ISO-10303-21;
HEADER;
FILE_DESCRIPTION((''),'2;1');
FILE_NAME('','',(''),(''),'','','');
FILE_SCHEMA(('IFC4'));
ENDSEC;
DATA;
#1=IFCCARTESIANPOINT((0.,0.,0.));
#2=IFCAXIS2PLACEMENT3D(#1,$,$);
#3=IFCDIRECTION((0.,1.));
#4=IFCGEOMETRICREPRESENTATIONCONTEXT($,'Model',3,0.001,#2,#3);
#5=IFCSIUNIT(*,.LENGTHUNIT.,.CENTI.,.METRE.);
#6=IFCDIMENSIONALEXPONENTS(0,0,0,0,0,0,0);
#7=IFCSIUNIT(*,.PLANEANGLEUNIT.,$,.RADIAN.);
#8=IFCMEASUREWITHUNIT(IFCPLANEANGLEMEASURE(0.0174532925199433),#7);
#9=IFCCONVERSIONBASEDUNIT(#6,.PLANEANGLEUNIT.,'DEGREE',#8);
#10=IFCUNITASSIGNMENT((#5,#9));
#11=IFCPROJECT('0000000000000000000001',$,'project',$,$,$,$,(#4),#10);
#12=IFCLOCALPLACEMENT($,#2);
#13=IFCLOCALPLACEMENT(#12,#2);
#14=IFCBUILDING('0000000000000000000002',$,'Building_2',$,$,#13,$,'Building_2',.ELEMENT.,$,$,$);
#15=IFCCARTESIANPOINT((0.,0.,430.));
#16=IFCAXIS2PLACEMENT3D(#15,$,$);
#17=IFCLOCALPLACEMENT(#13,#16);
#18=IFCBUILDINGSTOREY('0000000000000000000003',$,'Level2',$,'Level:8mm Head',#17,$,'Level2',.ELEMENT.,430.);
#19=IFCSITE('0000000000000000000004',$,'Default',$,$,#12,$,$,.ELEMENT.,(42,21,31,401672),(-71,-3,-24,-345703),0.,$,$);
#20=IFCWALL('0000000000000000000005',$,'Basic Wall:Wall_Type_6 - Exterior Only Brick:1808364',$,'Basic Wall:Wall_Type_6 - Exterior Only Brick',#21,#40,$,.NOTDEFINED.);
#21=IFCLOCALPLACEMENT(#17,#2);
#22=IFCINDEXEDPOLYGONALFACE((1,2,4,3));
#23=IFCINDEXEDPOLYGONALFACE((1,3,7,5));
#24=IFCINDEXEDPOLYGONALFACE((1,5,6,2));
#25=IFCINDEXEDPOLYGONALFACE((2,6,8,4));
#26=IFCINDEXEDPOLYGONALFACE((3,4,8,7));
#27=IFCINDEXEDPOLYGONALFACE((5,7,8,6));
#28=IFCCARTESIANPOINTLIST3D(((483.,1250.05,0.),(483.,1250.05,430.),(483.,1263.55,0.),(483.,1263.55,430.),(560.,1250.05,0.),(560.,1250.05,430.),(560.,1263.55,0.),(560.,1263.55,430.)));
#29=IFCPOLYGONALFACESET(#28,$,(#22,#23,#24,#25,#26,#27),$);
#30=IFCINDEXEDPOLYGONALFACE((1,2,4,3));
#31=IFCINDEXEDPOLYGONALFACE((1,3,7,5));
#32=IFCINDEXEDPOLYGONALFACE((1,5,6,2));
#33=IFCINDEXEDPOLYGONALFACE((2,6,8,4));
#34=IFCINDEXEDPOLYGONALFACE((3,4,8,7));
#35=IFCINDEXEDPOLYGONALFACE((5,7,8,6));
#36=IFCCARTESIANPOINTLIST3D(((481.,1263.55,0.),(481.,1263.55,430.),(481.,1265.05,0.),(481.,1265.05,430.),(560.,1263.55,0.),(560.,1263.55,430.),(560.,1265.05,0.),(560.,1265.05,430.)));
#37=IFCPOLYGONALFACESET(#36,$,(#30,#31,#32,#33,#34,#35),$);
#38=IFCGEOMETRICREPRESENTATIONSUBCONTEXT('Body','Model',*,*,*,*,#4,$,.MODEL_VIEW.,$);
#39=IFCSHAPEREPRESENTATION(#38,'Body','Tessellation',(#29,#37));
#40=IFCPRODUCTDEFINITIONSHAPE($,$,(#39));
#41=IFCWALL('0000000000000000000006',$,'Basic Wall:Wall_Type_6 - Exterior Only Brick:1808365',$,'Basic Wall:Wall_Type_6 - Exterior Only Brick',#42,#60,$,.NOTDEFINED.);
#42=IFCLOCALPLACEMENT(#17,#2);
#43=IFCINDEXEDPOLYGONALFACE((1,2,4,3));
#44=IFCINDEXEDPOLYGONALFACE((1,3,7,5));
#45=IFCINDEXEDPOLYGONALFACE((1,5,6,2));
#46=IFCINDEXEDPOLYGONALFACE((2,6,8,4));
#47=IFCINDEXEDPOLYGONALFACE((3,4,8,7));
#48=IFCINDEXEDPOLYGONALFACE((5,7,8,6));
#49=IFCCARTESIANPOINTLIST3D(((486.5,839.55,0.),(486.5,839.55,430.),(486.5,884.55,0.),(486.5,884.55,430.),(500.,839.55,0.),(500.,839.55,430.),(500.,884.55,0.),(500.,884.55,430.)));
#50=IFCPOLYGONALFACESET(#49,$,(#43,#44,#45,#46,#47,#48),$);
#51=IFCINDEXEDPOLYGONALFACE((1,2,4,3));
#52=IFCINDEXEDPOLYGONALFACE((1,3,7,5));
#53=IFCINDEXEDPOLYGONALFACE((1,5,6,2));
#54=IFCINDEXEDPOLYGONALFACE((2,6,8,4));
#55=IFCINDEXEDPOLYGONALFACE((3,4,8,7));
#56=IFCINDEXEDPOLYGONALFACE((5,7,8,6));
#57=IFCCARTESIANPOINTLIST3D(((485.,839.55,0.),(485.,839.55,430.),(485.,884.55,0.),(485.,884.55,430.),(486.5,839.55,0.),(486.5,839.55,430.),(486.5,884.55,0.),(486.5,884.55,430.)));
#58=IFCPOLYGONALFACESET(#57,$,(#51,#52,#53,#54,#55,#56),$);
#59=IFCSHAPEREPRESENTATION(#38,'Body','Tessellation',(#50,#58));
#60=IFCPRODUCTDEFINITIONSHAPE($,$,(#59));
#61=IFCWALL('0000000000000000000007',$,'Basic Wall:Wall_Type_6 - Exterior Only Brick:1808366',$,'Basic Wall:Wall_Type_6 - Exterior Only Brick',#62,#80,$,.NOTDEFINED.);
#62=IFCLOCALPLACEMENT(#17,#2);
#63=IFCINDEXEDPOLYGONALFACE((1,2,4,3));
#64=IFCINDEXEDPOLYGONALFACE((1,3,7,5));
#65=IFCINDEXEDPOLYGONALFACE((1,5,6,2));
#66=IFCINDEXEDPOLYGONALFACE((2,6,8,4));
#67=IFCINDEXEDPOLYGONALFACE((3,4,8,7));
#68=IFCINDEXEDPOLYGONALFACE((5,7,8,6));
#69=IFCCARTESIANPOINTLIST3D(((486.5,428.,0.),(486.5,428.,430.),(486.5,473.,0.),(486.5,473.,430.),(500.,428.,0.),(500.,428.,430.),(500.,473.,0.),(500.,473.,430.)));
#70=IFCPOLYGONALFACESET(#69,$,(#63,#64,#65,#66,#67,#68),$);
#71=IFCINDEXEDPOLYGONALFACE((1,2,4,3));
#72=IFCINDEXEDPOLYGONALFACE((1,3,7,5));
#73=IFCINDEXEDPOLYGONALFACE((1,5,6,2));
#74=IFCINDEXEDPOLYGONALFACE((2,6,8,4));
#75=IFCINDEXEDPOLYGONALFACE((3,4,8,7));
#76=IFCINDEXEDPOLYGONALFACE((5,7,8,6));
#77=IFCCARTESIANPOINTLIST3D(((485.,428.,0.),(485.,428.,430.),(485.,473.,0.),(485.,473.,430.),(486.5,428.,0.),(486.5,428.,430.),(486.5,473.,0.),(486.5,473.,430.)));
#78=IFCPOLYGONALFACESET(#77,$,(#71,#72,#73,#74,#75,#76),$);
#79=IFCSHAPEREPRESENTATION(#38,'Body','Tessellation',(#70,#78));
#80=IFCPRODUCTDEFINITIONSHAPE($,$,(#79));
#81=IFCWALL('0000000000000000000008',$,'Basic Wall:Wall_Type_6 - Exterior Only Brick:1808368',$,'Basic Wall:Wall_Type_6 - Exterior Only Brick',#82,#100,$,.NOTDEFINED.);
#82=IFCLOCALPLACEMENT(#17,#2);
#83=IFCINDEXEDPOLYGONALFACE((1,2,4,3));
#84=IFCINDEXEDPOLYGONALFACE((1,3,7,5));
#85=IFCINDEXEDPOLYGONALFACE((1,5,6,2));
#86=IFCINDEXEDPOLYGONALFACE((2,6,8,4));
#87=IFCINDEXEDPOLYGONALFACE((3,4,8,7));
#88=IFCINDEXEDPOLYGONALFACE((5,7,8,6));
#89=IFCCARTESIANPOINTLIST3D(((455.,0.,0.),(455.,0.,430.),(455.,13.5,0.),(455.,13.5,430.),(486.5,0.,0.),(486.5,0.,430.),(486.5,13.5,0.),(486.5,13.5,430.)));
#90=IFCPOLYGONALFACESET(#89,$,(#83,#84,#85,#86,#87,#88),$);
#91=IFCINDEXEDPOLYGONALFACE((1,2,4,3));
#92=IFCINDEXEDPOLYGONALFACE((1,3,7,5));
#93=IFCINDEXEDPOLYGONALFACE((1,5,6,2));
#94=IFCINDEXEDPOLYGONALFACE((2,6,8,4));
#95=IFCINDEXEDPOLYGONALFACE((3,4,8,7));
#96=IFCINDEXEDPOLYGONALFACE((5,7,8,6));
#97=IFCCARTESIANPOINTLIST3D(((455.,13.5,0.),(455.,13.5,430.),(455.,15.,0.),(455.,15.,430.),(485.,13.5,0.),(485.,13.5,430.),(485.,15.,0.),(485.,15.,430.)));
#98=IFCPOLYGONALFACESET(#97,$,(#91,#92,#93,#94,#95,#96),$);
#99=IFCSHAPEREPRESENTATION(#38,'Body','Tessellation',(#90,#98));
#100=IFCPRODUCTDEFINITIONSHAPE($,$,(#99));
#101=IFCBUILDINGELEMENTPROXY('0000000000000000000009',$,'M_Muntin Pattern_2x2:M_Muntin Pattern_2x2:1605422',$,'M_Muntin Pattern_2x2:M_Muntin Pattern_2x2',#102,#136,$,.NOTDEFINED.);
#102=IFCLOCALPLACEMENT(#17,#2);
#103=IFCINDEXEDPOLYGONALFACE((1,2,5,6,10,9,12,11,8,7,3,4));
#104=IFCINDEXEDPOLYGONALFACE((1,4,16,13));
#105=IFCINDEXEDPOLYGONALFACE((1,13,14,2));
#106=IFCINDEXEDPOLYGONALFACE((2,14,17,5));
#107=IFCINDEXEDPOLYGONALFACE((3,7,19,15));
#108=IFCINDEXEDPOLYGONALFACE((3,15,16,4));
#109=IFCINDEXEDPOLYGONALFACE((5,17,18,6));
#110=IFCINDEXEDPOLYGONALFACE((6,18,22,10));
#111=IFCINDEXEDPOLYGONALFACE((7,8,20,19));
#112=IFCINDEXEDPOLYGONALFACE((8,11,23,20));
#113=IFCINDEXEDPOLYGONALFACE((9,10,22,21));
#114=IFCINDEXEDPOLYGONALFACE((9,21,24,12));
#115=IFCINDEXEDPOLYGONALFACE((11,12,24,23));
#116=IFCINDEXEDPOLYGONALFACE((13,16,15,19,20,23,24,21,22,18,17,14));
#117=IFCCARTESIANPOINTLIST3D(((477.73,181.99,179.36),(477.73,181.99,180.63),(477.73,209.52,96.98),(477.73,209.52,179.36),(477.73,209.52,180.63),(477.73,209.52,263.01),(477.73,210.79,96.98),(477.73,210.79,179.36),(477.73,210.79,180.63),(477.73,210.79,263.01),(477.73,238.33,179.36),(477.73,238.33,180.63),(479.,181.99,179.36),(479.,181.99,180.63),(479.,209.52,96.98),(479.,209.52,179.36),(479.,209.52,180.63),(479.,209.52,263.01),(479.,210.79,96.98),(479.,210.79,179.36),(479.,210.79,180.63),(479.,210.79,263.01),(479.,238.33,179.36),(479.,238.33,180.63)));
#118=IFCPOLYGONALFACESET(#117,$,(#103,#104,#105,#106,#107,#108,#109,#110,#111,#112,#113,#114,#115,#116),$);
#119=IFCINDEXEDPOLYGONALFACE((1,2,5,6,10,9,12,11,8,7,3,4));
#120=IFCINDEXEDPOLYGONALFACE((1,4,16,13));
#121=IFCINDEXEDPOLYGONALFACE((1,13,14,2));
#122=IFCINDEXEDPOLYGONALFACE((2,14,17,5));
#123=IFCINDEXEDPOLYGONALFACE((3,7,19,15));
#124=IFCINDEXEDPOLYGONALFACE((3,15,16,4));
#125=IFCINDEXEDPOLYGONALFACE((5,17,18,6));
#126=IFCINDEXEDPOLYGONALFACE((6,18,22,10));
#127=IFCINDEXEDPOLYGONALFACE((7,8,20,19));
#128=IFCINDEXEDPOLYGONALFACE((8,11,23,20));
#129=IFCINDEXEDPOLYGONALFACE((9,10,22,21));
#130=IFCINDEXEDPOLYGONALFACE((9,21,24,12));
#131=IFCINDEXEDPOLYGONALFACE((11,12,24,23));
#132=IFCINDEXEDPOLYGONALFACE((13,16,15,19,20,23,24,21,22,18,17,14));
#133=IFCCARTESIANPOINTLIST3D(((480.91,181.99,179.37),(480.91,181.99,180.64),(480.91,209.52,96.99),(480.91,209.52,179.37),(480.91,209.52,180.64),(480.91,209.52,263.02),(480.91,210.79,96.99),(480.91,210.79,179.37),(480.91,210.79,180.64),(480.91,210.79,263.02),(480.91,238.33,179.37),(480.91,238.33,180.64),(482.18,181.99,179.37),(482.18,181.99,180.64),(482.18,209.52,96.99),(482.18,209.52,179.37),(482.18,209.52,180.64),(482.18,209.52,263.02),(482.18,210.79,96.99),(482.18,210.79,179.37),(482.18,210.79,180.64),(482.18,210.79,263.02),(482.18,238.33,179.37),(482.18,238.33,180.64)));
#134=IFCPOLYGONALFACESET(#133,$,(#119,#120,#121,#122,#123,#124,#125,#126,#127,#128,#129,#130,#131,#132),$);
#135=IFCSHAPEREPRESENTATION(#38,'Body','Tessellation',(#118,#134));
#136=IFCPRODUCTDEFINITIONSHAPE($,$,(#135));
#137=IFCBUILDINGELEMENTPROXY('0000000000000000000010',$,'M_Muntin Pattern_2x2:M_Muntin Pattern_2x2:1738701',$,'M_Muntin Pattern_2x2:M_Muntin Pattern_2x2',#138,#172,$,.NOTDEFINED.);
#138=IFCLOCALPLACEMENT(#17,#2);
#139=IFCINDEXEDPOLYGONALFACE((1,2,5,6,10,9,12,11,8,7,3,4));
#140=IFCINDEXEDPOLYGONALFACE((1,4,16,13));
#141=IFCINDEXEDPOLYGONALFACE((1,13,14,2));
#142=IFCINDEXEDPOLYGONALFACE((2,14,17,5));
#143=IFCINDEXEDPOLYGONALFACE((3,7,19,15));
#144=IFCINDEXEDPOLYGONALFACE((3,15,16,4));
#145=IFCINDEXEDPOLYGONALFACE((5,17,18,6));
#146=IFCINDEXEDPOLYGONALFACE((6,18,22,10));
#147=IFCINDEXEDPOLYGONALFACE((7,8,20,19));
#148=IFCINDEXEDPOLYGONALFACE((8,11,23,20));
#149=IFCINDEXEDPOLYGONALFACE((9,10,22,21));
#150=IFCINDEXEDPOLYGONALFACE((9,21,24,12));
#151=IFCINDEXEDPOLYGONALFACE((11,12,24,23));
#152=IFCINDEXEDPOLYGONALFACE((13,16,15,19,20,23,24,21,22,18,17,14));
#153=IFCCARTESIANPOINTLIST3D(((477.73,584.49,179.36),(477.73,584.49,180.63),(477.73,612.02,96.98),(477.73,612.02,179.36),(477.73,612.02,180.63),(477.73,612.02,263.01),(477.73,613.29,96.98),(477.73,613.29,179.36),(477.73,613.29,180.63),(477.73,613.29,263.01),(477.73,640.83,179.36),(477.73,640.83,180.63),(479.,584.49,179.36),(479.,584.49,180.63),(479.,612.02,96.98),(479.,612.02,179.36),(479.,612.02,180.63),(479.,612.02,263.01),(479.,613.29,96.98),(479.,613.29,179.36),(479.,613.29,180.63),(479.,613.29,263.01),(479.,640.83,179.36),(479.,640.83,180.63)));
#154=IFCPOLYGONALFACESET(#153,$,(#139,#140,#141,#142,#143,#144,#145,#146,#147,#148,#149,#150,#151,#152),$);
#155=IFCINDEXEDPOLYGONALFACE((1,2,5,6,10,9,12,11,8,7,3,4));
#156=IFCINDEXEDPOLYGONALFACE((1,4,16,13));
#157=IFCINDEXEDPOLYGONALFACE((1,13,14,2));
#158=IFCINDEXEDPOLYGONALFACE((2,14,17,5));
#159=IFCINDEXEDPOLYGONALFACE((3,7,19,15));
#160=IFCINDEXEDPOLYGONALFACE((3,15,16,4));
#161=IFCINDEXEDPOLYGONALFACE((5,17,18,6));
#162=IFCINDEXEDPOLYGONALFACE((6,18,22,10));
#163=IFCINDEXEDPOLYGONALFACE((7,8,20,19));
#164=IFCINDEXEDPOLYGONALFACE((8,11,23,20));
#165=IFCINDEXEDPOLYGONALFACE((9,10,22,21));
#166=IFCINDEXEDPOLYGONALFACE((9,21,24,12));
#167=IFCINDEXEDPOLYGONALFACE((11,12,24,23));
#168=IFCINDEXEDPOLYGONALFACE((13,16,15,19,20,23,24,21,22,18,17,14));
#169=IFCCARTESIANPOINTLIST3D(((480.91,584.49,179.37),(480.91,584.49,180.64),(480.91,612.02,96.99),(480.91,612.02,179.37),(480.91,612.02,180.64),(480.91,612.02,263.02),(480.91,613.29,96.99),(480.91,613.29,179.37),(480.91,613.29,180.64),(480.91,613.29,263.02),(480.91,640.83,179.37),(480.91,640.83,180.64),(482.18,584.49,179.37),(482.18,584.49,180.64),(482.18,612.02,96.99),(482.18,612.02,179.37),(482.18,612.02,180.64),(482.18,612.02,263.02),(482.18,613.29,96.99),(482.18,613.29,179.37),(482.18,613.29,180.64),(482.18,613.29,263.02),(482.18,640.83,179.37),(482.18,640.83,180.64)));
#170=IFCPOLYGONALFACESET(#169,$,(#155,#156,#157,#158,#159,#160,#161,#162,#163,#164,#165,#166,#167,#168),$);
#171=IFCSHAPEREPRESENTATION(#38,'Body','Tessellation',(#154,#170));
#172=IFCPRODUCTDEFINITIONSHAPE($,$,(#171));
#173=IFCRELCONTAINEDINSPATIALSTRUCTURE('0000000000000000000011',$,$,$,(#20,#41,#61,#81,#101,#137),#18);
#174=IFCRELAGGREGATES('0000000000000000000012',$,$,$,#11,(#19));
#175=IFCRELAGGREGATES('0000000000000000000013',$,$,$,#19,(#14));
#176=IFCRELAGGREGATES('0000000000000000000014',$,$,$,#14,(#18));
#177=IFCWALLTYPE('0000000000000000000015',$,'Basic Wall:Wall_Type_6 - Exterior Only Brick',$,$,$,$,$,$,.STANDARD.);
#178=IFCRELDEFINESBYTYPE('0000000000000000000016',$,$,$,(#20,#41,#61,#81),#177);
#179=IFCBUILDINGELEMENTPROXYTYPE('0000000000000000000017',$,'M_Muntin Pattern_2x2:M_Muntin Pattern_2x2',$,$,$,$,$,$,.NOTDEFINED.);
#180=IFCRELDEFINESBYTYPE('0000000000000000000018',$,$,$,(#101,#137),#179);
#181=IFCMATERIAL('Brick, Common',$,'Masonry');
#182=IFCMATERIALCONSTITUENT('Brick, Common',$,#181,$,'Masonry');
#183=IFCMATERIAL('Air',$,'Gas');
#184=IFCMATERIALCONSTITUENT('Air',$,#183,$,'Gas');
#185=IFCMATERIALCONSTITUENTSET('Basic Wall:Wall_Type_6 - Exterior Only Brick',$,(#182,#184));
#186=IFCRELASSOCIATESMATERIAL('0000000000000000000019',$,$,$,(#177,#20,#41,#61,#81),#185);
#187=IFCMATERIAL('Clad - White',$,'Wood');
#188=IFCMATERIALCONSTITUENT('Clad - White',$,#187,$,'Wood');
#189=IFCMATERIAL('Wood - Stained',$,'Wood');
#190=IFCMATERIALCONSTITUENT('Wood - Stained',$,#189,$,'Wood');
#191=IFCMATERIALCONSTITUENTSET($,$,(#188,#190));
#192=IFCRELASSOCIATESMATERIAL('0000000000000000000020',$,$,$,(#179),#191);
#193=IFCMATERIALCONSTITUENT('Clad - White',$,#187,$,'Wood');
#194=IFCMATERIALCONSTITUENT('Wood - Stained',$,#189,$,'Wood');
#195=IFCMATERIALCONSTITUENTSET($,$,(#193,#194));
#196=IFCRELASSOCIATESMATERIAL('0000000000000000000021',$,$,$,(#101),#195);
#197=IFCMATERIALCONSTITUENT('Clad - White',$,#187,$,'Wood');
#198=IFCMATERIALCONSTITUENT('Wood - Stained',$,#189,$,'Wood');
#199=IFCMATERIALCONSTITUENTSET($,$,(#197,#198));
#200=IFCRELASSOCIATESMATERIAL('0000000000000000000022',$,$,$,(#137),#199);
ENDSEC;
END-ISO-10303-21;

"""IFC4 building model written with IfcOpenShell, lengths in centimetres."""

from ifc_helpers import new_model, entity, si_unit, converted_unit, direction, frame, origin, place, context, subcontext, project, spatial, indexed_curve, outline, extrude, source, transform, mapped, material, constituent, constituent_set, type_object, type_shapes, element, save


model = new_model("IFC4")

# Units and contexts
model_context = context("Model", 3, precision=0.001, world=origin(), true_north=direction((0.0, 1.0)))
body_context = subcontext(model_context, "Body", "Model", "MODEL_VIEW")
ifc_project = project(units=[si_unit("LENGTHUNIT", "METRE", prefix="CENTI"), converted_unit("PLANEANGLEUNIT", "DEGREE", entity("IfcPlaneAngleMeasure", 0.0174532925199433), si_unit("PLANEANGLEUNIT", "RADIAN"), dimensions=[0, 0, 0, 0, 0, 0, 0])], contexts=[model_context])

# Site, building, storey
site_placement = place(None, origin())
site = spatial("IfcSite", under=ifc_project, at=site_placement, Name="Default", CompositionType="ELEMENT", RefLatitude=(42, 21, 31, 401672), RefLongitude=(-71, -3, -24, -345703), RefElevation=0.0)
building_placement = place(site_placement, origin())
building = spatial("IfcBuilding", under=site, at=building_placement, Name="Building_2", LongName="Building_2", CompositionType="ELEMENT")
storey_placement = place(building_placement, frame((0.0, 0.0, 430.0)))
storey = spatial("IfcBuildingStorey", under=building, at=storey_placement, Name="Level2", ObjectType="Level:8mm Head", LongName="Level2", CompositionType="ELEMENT", Elevation=430.0)

# Shared definitions
ifc_material_1 = material(Name="Brick, Common", Category="Masonry")
ifc_material_2 = material(Name="Air", Category="Gas")

# Walls
ifc_constituent_1 = constituent(ifc_material_1, Name="Brick, Common", Category="Masonry")
ifc_constituent_2 = constituent(ifc_material_2, Name="Air", Category="Gas")
ifc_constituent_set_1 = constituent_set(constituents=[ifc_constituent_1, ifc_constituent_2], Name="Basic Wall:Wall_Type_6 - Exterior Only Brick")
wall_type_1 = type_object("IfcWallType", Name="Basic Wall:Wall_Type_6 - Exterior Only Brick", PredefinedType="STANDARD", material=ifc_constituent_set_1)
wall_1_placement = place(storey_placement, frame((560.0, 1257.55, 0.0), z_axis=(0.0, 0.0, 1.0), x_axis=(-1.0, 0.0, 0.0)))
element("IfcWall", 1, at=wall_1_placement, inside=storey, type_object=wall_type_1, material=ifc_constituent_set_1, Name="Basic Wall:Wall_Type_6 - Exterior Only Brick:1808364", ObjectType="Basic Wall:Wall_Type_6 - Exterior Only Brick", PredefinedType="NOTDEFINED", context=body_context, shape_type="SweptSolid", body=[
    extrude(outline(indexed_curve([(-6.75, -38.5), (6.75, -38.5), (6.75, 38.5), (-6.75, 38.5), (-6.75, -38.5)], self_intersect=False)), frame((38.5, 0.75, 0.0), z_axis=(0.0, 0.0, 1.0), x_axis=(0.0, -1.0, 0.0)), (0.0, 0.0, 1.0), 430.0),
    extrude(outline(indexed_curve([(-0.75, -39.5), (0.75, -39.5), (0.75, 39.5), (-0.75, 39.5), (-0.75, -39.5)], self_intersect=False)), frame((39.5, -6.75, 0.0), z_axis=(0.0, 0.0, 1.0), x_axis=(0.0, -1.0, 0.0)), (0.0, 0.0, 1.0), 430.0),
])
wall_2_placement = place(storey_placement, frame((492.5, 884.55, 0.0), z_axis=(0.0, 0.0, 1.0), x_axis=(0.0, -1.0, 0.0)))
element("IfcWall", 2, at=wall_2_placement, inside=storey, type_object=wall_type_1, material=ifc_constituent_set_1, Name="Basic Wall:Wall_Type_6 - Exterior Only Brick:1808365", ObjectType="Basic Wall:Wall_Type_6 - Exterior Only Brick", PredefinedType="NOTDEFINED", context=body_context, shape_type="SweptSolid", body=[
    extrude(outline(indexed_curve([(-6.75, -22.5), (6.75, -22.5), (6.75, 22.5), (-6.75, 22.5), (-6.75, -22.5)], self_intersect=False)), frame((22.5, 0.75, 0.0), z_axis=(0.0, 0.0, 1.0), x_axis=(0.0, -1.0, 0.0)), (0.0, 0.0, 1.0), 430.0),
    extrude(outline(indexed_curve([(-0.75, -22.5), (0.75, -22.5), (0.75, 22.5), (-0.75, 22.5), (-0.75, -22.5)], self_intersect=False)), frame((22.5, -6.75, 0.0), z_axis=(0.0, 0.0, 1.0), x_axis=(0.0, 1.0, 0.0)), (0.0, 0.0, 1.0), 430.0),
])
wall_3_placement = place(storey_placement, frame((492.5, 473.0, 0.0), z_axis=(0.0, 0.0, 1.0), x_axis=(0.0, -1.0, 0.0)))
element("IfcWall", 3, at=wall_3_placement, inside=storey, type_object=wall_type_1, material=ifc_constituent_set_1, Name="Basic Wall:Wall_Type_6 - Exterior Only Brick:1808366", ObjectType="Basic Wall:Wall_Type_6 - Exterior Only Brick", PredefinedType="NOTDEFINED", context=body_context, shape_type="SweptSolid", body=[
    extrude(outline(indexed_curve([(-6.75, -22.5), (6.75, -22.5), (6.75, 22.5), (-6.75, 22.5), (-6.75, -22.5)], self_intersect=False)), frame((22.5, 0.75, 0.0), z_axis=(0.0, 0.0, 1.0), x_axis=(0.0, -1.0, 0.0)), (0.0, 0.0, 1.0), 430.0),
    extrude(outline(indexed_curve([(-0.75, -22.5), (0.75, -22.5), (0.75, 22.5), (-0.75, 22.5), (-0.75, -22.5)], self_intersect=False)), frame((22.5, -6.75, 0.0), z_axis=(0.0, 0.0, 1.0), x_axis=(0.0, 1.0, 0.0)), (0.0, 0.0, 1.0), 430.0),
])
wall_4_placement = place(storey_placement, frame((485.0, 7.5, 0.0), z_axis=(0.0, 0.0, 1.0), x_axis=(-1.0, 0.0, 0.0)))
element("IfcWall", 4, at=wall_4_placement, inside=storey, type_object=wall_type_1, material=ifc_constituent_set_1, Name="Basic Wall:Wall_Type_6 - Exterior Only Brick:1808368", ObjectType="Basic Wall:Wall_Type_6 - Exterior Only Brick", PredefinedType="NOTDEFINED", context=body_context, shape_type="SweptSolid", body=[
    extrude(outline(indexed_curve([(-6.75, -15.75), (6.75, -15.75), (6.75, 15.75), (-6.75, 15.75), (-6.75, -15.75)], self_intersect=False)), frame((14.25, 0.75, 0.0), z_axis=(0.0, 0.0, 1.0), x_axis=(0.0, -1.0, 0.0)), (0.0, 0.0, 1.0), 430.0),
    extrude(outline(indexed_curve([(-0.75, -15.0), (0.75, -15.0), (0.75, 15.0), (-0.75, 15.0), (-0.75, -15.0)], self_intersect=False)), frame((15.0, -6.75, 0.0), z_axis=(0.0, 0.0, 1.0), x_axis=(0.0, 1.0, 0.0)), (0.0, 0.0, 1.0), 430.0),
])

# Building element proxies
ifc_material_3 = material(Name="Clad - White", Category="Wood")
ifc_constituent_3 = constituent(ifc_material_3, Name="Clad - White", Category="Wood")
ifc_material_4 = material(Name="Wood - Stained", Category="Wood")
ifc_constituent_4 = constituent(ifc_material_4, Name="Wood - Stained", Category="Wood")
ifc_constituent_set_2 = constituent_set(constituents=[ifc_constituent_3, ifc_constituent_4])
ifc_constituent_5 = constituent(ifc_material_3, Name="Clad - White", Category="Wood")
ifc_constituent_6 = constituent(ifc_material_4, Name="Wood - Stained", Category="Wood")
ifc_constituent_set_3 = constituent_set(constituents=[ifc_constituent_5, ifc_constituent_6])
building_element_proxy_type_1 = type_object("IfcBuildingElementProxyType", Name="M_Muntin Pattern_2x2:M_Muntin Pattern_2x2", PredefinedType="NOTDEFINED", material=ifc_constituent_set_3)
shared_shape_1 = source(origin(), body_context, "Body", "SweptSolid", [
    extrude(outline(indexed_curve([(0.64, -0.64), (83.01, -0.64), (83.01, 0.63), (0.64, 0.63), (0.64, 28.17), (-0.63, 28.17), (-0.63, 0.63), (-83.02, 0.63), (-83.02, -0.64), (-0.63, -0.64), (-0.63, -28.17), (0.64, -28.17), (0.64, -0.64)], self_intersect=False)), frame((0.0, 0.95, 83.01), z_axis=(0.0, 1.0, 0.0), x_axis=(0.0, 0.0, 1.0)), (0.0, 0.0, 1.0), 1.27),
    extrude(outline(indexed_curve([(0.64, -0.64), (83.02, -0.64), (83.02, 0.63), (0.64, 0.63), (0.64, 28.17), (-0.63, 28.17), (-0.63, 0.63), (-83.02, 0.63), (-83.02, -0.64), (-0.63, -0.64), (-0.63, -28.17), (0.64, -28.17), (0.64, -0.64)], self_intersect=False)), frame((0.0, -2.22, 83.02), z_axis=(0.0, 1.0, 0.0), x_axis=(0.0, 0.0, 1.0)), (0.0, 0.0, 1.0), 1.27),
])
type_shapes(building_element_proxy_type_1, [shared_shape_1])
proxy_1_placement = place(storey_placement, frame((479.95, 210.16, 96.99), z_axis=(0.0, 0.0, 1.0), x_axis=(0.0, 1.0, 0.0)))
element("IfcBuildingElementProxy", 5, at=proxy_1_placement, inside=storey, type_object=building_element_proxy_type_1, material=ifc_constituent_set_2, Name="M_Muntin Pattern_2x2:M_Muntin Pattern_2x2:1605422", ObjectType="M_Muntin Pattern_2x2:M_Muntin Pattern_2x2", PredefinedType="NOTDEFINED", context=body_context, shape_type="MappedRepresentation", body=[
    mapped(shared_shape_1, transform((0.0, 0.0, 0.0), scale=1.0)),
])
ifc_constituent_7 = constituent(ifc_material_3, Name="Clad - White", Category="Wood")
ifc_constituent_8 = constituent(ifc_material_4, Name="Wood - Stained", Category="Wood")
ifc_constituent_set_4 = constituent_set(constituents=[ifc_constituent_7, ifc_constituent_8])
proxy_2_placement = place(storey_placement, frame((479.95, 612.66, 96.99), z_axis=(0.0, 0.0, 1.0), x_axis=(0.0, 1.0, 0.0)))
element("IfcBuildingElementProxy", 6, at=proxy_2_placement, inside=storey, type_object=building_element_proxy_type_1, material=ifc_constituent_set_4, Name="M_Muntin Pattern_2x2:M_Muntin Pattern_2x2:1738701", ObjectType="M_Muntin Pattern_2x2:M_Muntin Pattern_2x2", PredefinedType="NOTDEFINED", context=body_context, shape_type="MappedRepresentation", body=[
    mapped(shared_shape_1, transform((0.0, 0.0, 0.0), scale=1.0)),
])

save(model, "model.ifc")
